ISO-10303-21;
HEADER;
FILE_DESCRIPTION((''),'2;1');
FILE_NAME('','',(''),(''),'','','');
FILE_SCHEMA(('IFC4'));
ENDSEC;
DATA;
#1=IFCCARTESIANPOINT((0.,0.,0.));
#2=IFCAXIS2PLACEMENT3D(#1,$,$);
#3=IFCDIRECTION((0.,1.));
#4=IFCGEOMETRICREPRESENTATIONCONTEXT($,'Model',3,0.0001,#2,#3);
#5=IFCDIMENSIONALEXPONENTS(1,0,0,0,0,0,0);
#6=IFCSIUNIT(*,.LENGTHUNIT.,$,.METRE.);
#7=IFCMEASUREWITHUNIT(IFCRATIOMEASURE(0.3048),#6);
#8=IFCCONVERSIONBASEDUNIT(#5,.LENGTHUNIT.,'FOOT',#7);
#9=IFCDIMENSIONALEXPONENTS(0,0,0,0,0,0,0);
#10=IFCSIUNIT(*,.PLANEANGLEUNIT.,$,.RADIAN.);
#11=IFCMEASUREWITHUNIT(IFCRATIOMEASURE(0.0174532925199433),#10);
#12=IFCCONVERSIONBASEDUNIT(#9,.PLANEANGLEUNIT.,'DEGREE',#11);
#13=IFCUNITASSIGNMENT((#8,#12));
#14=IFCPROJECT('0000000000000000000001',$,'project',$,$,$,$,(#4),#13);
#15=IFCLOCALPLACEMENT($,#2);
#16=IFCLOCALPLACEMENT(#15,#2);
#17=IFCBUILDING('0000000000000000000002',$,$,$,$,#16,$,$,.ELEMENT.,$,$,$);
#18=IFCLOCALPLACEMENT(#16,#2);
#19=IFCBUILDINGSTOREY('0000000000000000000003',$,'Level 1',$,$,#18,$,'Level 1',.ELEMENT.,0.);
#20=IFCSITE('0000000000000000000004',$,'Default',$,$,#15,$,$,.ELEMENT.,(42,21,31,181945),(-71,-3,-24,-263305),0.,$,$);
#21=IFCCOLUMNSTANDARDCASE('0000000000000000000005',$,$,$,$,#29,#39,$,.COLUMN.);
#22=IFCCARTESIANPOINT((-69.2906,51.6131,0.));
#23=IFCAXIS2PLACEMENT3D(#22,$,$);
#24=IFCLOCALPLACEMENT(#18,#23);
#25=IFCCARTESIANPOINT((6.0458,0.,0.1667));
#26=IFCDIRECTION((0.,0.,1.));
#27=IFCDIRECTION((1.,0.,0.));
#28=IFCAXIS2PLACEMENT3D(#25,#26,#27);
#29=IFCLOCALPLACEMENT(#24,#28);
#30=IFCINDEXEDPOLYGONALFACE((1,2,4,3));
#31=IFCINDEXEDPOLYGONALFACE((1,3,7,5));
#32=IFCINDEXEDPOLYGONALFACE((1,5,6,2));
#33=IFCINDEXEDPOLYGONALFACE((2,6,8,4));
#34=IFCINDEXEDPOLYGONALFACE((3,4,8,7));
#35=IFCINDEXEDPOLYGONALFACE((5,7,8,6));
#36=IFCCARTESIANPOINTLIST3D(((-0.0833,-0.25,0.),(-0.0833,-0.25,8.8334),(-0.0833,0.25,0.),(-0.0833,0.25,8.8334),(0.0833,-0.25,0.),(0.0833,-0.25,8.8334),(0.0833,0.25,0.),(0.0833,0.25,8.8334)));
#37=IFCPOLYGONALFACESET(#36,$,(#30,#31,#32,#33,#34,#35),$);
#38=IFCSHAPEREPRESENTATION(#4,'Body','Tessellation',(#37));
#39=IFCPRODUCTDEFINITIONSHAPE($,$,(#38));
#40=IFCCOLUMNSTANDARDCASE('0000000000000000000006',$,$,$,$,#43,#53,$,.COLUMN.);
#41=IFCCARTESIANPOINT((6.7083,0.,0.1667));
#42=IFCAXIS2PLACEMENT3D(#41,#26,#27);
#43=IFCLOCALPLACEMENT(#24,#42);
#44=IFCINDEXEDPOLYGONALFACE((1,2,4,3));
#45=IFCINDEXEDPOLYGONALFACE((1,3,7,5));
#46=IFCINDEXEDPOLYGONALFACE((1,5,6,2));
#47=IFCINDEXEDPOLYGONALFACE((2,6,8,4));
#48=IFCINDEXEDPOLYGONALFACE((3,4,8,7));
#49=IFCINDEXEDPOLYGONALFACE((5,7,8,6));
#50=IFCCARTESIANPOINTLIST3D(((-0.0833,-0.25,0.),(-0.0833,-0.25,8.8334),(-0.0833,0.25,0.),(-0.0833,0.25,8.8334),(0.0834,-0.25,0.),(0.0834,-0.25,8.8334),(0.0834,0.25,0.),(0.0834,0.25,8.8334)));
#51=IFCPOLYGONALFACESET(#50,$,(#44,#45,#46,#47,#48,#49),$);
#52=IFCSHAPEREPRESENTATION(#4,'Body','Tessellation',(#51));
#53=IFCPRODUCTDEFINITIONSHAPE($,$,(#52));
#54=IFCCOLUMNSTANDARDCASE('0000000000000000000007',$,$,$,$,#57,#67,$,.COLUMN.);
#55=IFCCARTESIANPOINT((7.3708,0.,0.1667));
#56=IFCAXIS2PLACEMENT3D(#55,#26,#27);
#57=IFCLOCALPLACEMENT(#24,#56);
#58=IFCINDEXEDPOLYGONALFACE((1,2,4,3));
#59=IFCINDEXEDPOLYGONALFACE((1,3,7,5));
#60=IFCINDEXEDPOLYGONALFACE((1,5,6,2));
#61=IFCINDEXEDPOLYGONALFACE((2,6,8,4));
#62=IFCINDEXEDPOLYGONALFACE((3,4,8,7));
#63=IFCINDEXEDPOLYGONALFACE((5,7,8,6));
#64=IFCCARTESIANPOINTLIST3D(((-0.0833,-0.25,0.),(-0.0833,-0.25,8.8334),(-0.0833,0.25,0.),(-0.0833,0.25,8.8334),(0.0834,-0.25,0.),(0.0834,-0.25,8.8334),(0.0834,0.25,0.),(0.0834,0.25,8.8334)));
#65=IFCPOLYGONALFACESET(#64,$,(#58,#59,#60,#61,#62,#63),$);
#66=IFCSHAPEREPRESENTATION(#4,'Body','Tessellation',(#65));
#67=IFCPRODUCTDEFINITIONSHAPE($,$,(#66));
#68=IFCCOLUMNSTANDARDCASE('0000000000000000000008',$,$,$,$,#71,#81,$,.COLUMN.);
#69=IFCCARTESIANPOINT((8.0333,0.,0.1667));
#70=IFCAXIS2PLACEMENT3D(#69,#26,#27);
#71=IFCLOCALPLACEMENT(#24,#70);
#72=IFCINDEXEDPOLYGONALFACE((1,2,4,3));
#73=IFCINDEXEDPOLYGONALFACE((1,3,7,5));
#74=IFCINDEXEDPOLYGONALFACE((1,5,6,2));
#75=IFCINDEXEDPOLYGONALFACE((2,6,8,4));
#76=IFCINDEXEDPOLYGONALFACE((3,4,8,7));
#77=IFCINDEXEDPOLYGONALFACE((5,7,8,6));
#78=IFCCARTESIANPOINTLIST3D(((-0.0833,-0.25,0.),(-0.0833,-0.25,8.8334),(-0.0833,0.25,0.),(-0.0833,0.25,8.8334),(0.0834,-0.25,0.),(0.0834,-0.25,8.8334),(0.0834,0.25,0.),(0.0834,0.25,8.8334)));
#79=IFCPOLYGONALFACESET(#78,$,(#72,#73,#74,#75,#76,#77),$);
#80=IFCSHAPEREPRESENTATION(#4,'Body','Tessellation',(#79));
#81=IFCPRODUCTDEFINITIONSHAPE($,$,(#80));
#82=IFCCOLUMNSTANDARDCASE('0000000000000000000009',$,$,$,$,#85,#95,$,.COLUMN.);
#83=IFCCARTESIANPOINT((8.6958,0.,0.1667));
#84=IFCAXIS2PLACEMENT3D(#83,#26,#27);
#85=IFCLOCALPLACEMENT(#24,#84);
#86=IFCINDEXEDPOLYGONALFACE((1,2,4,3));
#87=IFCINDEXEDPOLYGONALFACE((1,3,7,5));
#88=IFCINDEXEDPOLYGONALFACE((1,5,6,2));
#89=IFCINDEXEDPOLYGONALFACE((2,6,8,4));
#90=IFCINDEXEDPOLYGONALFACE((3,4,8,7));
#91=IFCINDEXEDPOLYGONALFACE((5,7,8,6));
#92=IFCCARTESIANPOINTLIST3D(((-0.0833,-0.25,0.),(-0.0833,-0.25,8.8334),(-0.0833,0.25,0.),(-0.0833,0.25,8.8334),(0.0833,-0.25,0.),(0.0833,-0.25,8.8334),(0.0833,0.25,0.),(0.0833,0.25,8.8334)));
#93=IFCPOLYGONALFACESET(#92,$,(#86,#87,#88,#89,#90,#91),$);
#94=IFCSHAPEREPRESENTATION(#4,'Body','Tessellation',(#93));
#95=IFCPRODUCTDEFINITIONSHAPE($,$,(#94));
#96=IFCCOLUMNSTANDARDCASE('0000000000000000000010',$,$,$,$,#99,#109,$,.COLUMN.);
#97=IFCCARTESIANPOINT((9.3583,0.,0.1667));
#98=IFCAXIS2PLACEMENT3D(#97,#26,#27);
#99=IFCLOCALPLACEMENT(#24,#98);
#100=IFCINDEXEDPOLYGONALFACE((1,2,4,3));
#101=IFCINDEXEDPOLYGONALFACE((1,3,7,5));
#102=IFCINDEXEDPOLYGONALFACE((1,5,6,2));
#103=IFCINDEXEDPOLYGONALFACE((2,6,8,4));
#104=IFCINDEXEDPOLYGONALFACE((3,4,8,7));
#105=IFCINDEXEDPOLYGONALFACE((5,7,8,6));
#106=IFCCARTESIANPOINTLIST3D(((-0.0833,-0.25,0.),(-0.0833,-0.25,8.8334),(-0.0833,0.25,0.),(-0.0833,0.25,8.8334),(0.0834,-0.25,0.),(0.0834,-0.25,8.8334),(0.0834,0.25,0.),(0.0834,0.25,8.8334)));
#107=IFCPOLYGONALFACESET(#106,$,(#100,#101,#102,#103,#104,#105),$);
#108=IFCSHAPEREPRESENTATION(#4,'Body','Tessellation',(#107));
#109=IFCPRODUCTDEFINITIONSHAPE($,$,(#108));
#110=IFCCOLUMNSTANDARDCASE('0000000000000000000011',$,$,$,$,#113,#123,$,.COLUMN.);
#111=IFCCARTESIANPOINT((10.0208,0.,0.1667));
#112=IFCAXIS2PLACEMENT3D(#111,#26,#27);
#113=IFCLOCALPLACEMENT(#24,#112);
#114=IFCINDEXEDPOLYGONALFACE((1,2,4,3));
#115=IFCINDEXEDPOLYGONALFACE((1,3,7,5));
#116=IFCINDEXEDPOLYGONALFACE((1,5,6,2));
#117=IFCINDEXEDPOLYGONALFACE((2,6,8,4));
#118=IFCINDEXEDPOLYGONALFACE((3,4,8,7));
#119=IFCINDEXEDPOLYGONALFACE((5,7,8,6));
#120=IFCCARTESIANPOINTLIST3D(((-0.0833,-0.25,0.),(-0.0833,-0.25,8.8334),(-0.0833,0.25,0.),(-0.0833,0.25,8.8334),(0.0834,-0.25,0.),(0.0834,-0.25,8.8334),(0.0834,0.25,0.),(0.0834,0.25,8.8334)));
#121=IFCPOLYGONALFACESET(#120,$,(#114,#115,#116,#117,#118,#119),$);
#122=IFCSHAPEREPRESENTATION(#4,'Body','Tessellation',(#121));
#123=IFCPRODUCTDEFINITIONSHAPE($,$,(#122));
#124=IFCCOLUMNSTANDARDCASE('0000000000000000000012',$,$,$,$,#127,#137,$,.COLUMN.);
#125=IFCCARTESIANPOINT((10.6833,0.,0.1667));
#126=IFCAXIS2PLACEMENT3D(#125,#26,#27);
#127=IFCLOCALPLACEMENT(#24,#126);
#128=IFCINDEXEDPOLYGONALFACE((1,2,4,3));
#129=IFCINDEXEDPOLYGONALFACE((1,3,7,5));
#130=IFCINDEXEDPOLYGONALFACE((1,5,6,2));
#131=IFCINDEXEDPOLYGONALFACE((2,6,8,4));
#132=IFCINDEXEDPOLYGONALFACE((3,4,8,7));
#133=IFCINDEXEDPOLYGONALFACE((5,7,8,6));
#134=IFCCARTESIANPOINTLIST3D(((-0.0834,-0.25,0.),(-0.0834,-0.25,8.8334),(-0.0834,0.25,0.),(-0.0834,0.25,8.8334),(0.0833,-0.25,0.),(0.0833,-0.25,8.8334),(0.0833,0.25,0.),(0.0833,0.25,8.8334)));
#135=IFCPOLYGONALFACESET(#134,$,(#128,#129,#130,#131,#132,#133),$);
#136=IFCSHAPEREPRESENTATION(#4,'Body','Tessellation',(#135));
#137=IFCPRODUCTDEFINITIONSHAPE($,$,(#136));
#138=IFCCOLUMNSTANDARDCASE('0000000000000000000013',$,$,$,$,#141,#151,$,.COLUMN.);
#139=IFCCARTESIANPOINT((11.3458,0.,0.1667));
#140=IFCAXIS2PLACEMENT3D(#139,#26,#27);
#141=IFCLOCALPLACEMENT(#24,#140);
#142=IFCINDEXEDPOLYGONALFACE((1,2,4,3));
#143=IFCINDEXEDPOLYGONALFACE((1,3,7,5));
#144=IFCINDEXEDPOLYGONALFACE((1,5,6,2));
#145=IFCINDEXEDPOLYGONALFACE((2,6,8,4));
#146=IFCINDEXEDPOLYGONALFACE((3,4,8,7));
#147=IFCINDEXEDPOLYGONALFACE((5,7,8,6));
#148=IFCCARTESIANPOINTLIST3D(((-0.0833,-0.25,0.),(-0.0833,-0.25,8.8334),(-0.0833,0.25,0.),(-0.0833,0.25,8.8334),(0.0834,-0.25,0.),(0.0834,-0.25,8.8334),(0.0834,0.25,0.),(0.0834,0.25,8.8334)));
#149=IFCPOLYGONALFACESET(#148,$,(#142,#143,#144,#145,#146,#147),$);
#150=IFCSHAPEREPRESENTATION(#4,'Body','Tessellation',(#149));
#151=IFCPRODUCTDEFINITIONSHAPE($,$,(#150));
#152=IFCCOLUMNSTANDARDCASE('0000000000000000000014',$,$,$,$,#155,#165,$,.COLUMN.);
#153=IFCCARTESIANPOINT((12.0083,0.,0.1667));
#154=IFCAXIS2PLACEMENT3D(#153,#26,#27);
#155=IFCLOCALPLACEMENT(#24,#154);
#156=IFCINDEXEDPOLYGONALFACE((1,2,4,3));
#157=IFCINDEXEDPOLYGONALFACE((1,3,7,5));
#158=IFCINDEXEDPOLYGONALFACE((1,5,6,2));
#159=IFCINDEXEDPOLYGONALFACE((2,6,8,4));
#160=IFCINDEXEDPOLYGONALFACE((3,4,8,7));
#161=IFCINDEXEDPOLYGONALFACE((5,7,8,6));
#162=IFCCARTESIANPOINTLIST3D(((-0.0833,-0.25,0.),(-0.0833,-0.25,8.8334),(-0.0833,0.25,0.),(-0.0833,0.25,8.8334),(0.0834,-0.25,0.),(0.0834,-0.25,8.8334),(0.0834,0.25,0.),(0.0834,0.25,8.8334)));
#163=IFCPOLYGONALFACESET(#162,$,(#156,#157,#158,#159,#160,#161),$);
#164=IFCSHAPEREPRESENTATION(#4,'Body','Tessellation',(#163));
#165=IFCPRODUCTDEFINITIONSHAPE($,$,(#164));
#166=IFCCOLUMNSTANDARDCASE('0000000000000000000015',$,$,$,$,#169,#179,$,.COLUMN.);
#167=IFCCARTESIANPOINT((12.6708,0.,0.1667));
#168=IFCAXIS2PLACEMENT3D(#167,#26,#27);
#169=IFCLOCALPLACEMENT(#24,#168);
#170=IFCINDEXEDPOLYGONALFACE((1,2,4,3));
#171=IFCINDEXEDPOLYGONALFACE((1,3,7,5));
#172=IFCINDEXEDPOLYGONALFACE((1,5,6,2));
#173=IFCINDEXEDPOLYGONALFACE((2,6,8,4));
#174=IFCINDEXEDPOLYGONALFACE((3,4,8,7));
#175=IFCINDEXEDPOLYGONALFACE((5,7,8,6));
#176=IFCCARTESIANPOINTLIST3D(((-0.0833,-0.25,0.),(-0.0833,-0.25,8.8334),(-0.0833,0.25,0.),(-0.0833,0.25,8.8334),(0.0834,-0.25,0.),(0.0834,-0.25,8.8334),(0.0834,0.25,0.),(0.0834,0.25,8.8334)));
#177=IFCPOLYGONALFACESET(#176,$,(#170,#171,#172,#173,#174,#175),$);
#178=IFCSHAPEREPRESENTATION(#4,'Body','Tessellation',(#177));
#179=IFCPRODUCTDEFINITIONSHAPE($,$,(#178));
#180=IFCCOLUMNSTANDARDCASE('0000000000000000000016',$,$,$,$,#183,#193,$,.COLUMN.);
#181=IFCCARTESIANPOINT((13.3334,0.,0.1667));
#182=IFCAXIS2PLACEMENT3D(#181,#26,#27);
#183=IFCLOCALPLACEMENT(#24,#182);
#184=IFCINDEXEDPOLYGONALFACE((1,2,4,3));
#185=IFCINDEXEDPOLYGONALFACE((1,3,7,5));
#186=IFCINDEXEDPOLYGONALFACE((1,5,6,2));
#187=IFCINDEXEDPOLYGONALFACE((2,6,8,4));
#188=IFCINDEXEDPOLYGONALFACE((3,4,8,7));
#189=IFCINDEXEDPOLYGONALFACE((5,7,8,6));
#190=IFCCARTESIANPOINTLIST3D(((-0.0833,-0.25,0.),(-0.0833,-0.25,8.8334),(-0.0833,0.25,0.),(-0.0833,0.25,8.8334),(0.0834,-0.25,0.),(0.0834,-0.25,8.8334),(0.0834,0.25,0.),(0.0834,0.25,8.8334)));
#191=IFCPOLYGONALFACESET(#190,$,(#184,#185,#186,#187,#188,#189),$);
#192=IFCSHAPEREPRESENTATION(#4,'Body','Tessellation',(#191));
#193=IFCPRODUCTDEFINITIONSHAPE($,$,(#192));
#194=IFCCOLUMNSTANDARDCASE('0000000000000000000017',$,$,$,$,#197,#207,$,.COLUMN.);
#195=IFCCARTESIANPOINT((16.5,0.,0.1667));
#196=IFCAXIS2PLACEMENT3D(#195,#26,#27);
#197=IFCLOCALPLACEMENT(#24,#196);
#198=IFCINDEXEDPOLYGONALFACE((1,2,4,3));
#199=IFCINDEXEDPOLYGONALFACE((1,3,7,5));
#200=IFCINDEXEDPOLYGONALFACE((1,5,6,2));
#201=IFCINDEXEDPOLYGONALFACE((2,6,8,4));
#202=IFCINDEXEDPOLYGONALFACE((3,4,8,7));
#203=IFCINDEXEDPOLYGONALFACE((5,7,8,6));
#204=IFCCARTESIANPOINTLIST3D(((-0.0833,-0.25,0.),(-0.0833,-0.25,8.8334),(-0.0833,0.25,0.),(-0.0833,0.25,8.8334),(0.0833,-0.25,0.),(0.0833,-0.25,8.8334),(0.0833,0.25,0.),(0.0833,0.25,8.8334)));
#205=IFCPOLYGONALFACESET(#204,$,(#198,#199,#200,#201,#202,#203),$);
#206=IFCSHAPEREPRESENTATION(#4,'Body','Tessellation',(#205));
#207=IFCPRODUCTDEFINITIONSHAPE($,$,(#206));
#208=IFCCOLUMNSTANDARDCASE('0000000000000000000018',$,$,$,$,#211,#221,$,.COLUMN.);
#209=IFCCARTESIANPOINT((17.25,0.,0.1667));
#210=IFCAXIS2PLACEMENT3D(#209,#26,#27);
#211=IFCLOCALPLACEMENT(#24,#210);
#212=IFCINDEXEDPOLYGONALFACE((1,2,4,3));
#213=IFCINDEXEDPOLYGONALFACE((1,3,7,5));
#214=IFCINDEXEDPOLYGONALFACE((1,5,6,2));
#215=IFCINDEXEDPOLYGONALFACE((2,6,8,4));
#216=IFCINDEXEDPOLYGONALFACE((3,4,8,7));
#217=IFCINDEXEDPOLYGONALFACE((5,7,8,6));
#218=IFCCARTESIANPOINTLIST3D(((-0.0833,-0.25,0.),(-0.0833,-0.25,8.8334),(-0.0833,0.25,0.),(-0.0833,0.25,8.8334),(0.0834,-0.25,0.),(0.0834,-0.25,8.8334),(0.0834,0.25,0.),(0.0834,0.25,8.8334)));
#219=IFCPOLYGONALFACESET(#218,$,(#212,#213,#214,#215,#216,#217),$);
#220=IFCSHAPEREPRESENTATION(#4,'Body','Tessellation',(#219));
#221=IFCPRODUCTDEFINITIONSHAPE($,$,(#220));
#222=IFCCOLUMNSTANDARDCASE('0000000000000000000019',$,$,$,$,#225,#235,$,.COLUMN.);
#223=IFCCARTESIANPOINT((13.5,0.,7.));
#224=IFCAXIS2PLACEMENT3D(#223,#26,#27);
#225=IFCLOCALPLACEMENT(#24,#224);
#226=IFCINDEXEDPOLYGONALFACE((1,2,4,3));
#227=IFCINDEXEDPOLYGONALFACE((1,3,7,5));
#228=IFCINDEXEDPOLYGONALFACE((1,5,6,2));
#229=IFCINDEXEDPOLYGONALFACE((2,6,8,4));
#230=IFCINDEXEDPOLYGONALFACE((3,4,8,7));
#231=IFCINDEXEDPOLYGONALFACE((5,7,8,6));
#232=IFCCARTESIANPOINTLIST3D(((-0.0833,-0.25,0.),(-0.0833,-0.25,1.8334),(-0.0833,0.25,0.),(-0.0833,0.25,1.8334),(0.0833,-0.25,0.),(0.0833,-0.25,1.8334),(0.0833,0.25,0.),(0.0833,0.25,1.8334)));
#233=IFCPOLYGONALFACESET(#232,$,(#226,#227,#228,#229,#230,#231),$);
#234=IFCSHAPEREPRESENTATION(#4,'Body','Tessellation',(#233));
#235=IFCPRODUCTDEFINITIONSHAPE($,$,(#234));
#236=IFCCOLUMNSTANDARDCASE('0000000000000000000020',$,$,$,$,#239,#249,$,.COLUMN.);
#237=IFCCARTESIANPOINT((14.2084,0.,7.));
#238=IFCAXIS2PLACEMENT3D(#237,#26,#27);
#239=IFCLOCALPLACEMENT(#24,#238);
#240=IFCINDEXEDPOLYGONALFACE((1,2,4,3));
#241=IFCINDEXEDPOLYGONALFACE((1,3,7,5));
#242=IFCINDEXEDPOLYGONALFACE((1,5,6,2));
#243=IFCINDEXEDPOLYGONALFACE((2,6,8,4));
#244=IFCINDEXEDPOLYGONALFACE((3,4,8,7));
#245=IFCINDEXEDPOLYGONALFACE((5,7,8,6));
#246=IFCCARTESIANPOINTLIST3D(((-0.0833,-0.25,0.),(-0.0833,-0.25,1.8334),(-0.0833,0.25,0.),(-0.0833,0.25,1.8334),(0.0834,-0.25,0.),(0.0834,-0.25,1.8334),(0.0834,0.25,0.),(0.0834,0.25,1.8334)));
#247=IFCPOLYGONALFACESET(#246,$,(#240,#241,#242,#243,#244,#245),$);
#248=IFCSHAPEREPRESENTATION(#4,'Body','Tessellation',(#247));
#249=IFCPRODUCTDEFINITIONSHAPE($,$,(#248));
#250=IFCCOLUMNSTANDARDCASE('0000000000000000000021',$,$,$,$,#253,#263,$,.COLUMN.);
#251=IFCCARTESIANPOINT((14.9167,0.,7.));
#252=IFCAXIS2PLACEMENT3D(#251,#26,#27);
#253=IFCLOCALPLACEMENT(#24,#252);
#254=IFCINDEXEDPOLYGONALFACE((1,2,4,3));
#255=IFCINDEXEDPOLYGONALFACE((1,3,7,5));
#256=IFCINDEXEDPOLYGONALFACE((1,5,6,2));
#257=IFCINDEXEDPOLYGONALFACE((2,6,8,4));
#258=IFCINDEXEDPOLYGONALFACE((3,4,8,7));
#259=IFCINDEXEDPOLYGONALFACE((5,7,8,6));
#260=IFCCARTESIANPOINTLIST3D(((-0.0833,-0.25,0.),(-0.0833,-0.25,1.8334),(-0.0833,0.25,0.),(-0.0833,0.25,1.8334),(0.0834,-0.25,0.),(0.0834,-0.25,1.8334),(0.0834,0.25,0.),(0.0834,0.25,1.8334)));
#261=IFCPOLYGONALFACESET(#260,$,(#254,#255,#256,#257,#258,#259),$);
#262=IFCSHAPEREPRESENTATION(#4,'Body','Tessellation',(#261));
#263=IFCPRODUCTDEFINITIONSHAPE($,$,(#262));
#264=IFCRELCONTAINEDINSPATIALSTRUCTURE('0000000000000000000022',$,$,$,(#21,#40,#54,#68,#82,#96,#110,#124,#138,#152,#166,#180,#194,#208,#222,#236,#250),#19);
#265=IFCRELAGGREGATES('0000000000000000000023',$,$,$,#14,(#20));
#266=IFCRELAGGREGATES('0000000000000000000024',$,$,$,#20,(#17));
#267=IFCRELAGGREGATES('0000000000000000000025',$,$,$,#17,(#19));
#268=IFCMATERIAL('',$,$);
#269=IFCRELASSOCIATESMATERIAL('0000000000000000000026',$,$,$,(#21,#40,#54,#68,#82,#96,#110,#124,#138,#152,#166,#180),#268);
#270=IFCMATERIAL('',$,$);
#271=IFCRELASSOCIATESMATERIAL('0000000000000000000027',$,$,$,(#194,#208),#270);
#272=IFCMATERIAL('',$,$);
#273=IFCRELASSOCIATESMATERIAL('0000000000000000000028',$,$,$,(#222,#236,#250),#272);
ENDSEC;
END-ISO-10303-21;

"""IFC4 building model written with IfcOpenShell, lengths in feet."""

from ifc_helpers import new_model, entity, si_unit, converted_unit, direction, frame, origin, place, context, project, spatial, rectangle, extrude, material, element, save


model = new_model("IFC4")

# Units and contexts
model_context = context("Model", 3, precision=0.0001, world=origin(), true_north=direction((0.0, 1.0)))
ifc_project = project(units=[converted_unit("LENGTHUNIT", "FOOT", entity("IfcRatioMeasure", 0.3048), si_unit("LENGTHUNIT", "METRE"), dimensions=[1, 0, 0, 0, 0, 0, 0]), converted_unit("PLANEANGLEUNIT", "DEGREE", entity("IfcRatioMeasure", 0.0174532925199433), si_unit("PLANEANGLEUNIT", "RADIAN"), dimensions=[0, 0, 0, 0, 0, 0, 0])], contexts=[model_context])

# Site, building, storey
site_placement = place(None, origin())
site = spatial("IfcSite", under=ifc_project, at=site_placement, Name="Default", CompositionType="ELEMENT", RefLatitude=(42, 21, 31, 181945), RefLongitude=(-71, -3, -24, -263305), RefElevation=0.0)
building_placement = place(site_placement, origin())
building = spatial("IfcBuilding", under=site, at=building_placement, CompositionType="ELEMENT")
storey_placement = place(building_placement, origin())
storey = spatial("IfcBuildingStorey", under=building, at=storey_placement, Name="Level 1", LongName="Level 1", CompositionType="ELEMENT", Elevation=0.0)

# Columns
ifc_material_1 = material(Name="")
ifc_material_2 = material(Name="")
placement_1 = place(storey_placement, frame((-69.2906, 51.6131, 0.0)))
for number, where, z_axis, x_axis in (
    (1, (6.0458, 0.0, 0.1667), (0.0, 0.0, 1.0), (1.0, 0.0, 0.0)),
    (2, (6.7083, 0.0, 0.1667), (0.0, 0.0, 1.0), (1.0, 0.0, 0.0)),
    (3, (7.3708, 0.0, 0.1667), (0.0, 0.0, 1.0), (1.0, 0.0, 0.0)),
    (4, (8.0333, 0.0, 0.1667), (0.0, 0.0, 1.0), (1.0, 0.0, 0.0)),
    (5, (8.6958, 0.0, 0.1667), (0.0, 0.0, 1.0), (1.0, 0.0, 0.0)),
    (6, (9.3583, 0.0, 0.1667), (0.0, 0.0, 1.0), (1.0, 0.0, 0.0)),
    (7, (10.0208, 0.0, 0.1667), (0.0, 0.0, 1.0), (1.0, 0.0, 0.0)),
    (8, (10.6833, 0.0, 0.1667), (0.0, 0.0, 1.0), (1.0, 0.0, 0.0)),
    (9, (11.3458, 0.0, 0.1667), (0.0, 0.0, 1.0), (1.0, 0.0, 0.0)),
    (10, (12.0083, 0.0, 0.1667), (0.0, 0.0, 1.0), (1.0, 0.0, 0.0)),
    (11, (12.6708, 0.0, 0.1667), (0.0, 0.0, 1.0), (1.0, 0.0, 0.0)),
    (12, (13.3334, 0.0, 0.1667), (0.0, 0.0, 1.0), (1.0, 0.0, 0.0)),
):
    element("IfcColumnStandardCase", number, at=place(placement_1, frame(where, z_axis=z_axis, x_axis=x_axis)), inside=storey, material=ifc_material_2, PredefinedType="COLUMN", context=model_context, shape_type="SweptSolid", body=[
        extrude(rectangle(XDim=0.1667, YDim=0.5), origin(), (0.0, 0.0, 1.0), 8.8334),
    ])
for number, where, z_axis, x_axis in (
    (13, (16.5, 0.0, 0.1667), (0.0, 0.0, 1.0), (1.0, 0.0, 0.0)),
    (14, (17.25, 0.0, 0.1667), (0.0, 0.0, 1.0), (1.0, 0.0, 0.0)),
):
    element("IfcColumnStandardCase", number, at=place(placement_1, frame(where, z_axis=z_axis, x_axis=x_axis)), inside=storey, material=ifc_material_1, PredefinedType="COLUMN", context=model_context, shape_type="SweptSolid", body=[
        extrude(rectangle(XDim=0.1667, YDim=0.5), origin(), (0.0, 0.0, 1.0), 8.8334),
    ])
ifc_material_3 = material(Name="")
for number, where, z_axis, x_axis in (
    (15, (13.5, 0.0, 7.0), (0.0, 0.0, 1.0), (1.0, 0.0, 0.0)),
    (16, (14.2084, 0.0, 7.0), (0.0, 0.0, 1.0), (1.0, 0.0, 0.0)),
    (17, (14.9167, 0.0, 7.0), (0.0, 0.0, 1.0), (1.0, 0.0, 0.0)),
):
    element("IfcColumnStandardCase", number, at=place(placement_1, frame(where, z_axis=z_axis, x_axis=x_axis)), inside=storey, material=ifc_material_3, PredefinedType="COLUMN", context=model_context, shape_type="SweptSolid", body=[
        extrude(rectangle(XDim=0.1667, YDim=0.5), origin(), (0.0, 0.0, 1.0), 1.8334),
    ])

save(model, "model.ifc")
